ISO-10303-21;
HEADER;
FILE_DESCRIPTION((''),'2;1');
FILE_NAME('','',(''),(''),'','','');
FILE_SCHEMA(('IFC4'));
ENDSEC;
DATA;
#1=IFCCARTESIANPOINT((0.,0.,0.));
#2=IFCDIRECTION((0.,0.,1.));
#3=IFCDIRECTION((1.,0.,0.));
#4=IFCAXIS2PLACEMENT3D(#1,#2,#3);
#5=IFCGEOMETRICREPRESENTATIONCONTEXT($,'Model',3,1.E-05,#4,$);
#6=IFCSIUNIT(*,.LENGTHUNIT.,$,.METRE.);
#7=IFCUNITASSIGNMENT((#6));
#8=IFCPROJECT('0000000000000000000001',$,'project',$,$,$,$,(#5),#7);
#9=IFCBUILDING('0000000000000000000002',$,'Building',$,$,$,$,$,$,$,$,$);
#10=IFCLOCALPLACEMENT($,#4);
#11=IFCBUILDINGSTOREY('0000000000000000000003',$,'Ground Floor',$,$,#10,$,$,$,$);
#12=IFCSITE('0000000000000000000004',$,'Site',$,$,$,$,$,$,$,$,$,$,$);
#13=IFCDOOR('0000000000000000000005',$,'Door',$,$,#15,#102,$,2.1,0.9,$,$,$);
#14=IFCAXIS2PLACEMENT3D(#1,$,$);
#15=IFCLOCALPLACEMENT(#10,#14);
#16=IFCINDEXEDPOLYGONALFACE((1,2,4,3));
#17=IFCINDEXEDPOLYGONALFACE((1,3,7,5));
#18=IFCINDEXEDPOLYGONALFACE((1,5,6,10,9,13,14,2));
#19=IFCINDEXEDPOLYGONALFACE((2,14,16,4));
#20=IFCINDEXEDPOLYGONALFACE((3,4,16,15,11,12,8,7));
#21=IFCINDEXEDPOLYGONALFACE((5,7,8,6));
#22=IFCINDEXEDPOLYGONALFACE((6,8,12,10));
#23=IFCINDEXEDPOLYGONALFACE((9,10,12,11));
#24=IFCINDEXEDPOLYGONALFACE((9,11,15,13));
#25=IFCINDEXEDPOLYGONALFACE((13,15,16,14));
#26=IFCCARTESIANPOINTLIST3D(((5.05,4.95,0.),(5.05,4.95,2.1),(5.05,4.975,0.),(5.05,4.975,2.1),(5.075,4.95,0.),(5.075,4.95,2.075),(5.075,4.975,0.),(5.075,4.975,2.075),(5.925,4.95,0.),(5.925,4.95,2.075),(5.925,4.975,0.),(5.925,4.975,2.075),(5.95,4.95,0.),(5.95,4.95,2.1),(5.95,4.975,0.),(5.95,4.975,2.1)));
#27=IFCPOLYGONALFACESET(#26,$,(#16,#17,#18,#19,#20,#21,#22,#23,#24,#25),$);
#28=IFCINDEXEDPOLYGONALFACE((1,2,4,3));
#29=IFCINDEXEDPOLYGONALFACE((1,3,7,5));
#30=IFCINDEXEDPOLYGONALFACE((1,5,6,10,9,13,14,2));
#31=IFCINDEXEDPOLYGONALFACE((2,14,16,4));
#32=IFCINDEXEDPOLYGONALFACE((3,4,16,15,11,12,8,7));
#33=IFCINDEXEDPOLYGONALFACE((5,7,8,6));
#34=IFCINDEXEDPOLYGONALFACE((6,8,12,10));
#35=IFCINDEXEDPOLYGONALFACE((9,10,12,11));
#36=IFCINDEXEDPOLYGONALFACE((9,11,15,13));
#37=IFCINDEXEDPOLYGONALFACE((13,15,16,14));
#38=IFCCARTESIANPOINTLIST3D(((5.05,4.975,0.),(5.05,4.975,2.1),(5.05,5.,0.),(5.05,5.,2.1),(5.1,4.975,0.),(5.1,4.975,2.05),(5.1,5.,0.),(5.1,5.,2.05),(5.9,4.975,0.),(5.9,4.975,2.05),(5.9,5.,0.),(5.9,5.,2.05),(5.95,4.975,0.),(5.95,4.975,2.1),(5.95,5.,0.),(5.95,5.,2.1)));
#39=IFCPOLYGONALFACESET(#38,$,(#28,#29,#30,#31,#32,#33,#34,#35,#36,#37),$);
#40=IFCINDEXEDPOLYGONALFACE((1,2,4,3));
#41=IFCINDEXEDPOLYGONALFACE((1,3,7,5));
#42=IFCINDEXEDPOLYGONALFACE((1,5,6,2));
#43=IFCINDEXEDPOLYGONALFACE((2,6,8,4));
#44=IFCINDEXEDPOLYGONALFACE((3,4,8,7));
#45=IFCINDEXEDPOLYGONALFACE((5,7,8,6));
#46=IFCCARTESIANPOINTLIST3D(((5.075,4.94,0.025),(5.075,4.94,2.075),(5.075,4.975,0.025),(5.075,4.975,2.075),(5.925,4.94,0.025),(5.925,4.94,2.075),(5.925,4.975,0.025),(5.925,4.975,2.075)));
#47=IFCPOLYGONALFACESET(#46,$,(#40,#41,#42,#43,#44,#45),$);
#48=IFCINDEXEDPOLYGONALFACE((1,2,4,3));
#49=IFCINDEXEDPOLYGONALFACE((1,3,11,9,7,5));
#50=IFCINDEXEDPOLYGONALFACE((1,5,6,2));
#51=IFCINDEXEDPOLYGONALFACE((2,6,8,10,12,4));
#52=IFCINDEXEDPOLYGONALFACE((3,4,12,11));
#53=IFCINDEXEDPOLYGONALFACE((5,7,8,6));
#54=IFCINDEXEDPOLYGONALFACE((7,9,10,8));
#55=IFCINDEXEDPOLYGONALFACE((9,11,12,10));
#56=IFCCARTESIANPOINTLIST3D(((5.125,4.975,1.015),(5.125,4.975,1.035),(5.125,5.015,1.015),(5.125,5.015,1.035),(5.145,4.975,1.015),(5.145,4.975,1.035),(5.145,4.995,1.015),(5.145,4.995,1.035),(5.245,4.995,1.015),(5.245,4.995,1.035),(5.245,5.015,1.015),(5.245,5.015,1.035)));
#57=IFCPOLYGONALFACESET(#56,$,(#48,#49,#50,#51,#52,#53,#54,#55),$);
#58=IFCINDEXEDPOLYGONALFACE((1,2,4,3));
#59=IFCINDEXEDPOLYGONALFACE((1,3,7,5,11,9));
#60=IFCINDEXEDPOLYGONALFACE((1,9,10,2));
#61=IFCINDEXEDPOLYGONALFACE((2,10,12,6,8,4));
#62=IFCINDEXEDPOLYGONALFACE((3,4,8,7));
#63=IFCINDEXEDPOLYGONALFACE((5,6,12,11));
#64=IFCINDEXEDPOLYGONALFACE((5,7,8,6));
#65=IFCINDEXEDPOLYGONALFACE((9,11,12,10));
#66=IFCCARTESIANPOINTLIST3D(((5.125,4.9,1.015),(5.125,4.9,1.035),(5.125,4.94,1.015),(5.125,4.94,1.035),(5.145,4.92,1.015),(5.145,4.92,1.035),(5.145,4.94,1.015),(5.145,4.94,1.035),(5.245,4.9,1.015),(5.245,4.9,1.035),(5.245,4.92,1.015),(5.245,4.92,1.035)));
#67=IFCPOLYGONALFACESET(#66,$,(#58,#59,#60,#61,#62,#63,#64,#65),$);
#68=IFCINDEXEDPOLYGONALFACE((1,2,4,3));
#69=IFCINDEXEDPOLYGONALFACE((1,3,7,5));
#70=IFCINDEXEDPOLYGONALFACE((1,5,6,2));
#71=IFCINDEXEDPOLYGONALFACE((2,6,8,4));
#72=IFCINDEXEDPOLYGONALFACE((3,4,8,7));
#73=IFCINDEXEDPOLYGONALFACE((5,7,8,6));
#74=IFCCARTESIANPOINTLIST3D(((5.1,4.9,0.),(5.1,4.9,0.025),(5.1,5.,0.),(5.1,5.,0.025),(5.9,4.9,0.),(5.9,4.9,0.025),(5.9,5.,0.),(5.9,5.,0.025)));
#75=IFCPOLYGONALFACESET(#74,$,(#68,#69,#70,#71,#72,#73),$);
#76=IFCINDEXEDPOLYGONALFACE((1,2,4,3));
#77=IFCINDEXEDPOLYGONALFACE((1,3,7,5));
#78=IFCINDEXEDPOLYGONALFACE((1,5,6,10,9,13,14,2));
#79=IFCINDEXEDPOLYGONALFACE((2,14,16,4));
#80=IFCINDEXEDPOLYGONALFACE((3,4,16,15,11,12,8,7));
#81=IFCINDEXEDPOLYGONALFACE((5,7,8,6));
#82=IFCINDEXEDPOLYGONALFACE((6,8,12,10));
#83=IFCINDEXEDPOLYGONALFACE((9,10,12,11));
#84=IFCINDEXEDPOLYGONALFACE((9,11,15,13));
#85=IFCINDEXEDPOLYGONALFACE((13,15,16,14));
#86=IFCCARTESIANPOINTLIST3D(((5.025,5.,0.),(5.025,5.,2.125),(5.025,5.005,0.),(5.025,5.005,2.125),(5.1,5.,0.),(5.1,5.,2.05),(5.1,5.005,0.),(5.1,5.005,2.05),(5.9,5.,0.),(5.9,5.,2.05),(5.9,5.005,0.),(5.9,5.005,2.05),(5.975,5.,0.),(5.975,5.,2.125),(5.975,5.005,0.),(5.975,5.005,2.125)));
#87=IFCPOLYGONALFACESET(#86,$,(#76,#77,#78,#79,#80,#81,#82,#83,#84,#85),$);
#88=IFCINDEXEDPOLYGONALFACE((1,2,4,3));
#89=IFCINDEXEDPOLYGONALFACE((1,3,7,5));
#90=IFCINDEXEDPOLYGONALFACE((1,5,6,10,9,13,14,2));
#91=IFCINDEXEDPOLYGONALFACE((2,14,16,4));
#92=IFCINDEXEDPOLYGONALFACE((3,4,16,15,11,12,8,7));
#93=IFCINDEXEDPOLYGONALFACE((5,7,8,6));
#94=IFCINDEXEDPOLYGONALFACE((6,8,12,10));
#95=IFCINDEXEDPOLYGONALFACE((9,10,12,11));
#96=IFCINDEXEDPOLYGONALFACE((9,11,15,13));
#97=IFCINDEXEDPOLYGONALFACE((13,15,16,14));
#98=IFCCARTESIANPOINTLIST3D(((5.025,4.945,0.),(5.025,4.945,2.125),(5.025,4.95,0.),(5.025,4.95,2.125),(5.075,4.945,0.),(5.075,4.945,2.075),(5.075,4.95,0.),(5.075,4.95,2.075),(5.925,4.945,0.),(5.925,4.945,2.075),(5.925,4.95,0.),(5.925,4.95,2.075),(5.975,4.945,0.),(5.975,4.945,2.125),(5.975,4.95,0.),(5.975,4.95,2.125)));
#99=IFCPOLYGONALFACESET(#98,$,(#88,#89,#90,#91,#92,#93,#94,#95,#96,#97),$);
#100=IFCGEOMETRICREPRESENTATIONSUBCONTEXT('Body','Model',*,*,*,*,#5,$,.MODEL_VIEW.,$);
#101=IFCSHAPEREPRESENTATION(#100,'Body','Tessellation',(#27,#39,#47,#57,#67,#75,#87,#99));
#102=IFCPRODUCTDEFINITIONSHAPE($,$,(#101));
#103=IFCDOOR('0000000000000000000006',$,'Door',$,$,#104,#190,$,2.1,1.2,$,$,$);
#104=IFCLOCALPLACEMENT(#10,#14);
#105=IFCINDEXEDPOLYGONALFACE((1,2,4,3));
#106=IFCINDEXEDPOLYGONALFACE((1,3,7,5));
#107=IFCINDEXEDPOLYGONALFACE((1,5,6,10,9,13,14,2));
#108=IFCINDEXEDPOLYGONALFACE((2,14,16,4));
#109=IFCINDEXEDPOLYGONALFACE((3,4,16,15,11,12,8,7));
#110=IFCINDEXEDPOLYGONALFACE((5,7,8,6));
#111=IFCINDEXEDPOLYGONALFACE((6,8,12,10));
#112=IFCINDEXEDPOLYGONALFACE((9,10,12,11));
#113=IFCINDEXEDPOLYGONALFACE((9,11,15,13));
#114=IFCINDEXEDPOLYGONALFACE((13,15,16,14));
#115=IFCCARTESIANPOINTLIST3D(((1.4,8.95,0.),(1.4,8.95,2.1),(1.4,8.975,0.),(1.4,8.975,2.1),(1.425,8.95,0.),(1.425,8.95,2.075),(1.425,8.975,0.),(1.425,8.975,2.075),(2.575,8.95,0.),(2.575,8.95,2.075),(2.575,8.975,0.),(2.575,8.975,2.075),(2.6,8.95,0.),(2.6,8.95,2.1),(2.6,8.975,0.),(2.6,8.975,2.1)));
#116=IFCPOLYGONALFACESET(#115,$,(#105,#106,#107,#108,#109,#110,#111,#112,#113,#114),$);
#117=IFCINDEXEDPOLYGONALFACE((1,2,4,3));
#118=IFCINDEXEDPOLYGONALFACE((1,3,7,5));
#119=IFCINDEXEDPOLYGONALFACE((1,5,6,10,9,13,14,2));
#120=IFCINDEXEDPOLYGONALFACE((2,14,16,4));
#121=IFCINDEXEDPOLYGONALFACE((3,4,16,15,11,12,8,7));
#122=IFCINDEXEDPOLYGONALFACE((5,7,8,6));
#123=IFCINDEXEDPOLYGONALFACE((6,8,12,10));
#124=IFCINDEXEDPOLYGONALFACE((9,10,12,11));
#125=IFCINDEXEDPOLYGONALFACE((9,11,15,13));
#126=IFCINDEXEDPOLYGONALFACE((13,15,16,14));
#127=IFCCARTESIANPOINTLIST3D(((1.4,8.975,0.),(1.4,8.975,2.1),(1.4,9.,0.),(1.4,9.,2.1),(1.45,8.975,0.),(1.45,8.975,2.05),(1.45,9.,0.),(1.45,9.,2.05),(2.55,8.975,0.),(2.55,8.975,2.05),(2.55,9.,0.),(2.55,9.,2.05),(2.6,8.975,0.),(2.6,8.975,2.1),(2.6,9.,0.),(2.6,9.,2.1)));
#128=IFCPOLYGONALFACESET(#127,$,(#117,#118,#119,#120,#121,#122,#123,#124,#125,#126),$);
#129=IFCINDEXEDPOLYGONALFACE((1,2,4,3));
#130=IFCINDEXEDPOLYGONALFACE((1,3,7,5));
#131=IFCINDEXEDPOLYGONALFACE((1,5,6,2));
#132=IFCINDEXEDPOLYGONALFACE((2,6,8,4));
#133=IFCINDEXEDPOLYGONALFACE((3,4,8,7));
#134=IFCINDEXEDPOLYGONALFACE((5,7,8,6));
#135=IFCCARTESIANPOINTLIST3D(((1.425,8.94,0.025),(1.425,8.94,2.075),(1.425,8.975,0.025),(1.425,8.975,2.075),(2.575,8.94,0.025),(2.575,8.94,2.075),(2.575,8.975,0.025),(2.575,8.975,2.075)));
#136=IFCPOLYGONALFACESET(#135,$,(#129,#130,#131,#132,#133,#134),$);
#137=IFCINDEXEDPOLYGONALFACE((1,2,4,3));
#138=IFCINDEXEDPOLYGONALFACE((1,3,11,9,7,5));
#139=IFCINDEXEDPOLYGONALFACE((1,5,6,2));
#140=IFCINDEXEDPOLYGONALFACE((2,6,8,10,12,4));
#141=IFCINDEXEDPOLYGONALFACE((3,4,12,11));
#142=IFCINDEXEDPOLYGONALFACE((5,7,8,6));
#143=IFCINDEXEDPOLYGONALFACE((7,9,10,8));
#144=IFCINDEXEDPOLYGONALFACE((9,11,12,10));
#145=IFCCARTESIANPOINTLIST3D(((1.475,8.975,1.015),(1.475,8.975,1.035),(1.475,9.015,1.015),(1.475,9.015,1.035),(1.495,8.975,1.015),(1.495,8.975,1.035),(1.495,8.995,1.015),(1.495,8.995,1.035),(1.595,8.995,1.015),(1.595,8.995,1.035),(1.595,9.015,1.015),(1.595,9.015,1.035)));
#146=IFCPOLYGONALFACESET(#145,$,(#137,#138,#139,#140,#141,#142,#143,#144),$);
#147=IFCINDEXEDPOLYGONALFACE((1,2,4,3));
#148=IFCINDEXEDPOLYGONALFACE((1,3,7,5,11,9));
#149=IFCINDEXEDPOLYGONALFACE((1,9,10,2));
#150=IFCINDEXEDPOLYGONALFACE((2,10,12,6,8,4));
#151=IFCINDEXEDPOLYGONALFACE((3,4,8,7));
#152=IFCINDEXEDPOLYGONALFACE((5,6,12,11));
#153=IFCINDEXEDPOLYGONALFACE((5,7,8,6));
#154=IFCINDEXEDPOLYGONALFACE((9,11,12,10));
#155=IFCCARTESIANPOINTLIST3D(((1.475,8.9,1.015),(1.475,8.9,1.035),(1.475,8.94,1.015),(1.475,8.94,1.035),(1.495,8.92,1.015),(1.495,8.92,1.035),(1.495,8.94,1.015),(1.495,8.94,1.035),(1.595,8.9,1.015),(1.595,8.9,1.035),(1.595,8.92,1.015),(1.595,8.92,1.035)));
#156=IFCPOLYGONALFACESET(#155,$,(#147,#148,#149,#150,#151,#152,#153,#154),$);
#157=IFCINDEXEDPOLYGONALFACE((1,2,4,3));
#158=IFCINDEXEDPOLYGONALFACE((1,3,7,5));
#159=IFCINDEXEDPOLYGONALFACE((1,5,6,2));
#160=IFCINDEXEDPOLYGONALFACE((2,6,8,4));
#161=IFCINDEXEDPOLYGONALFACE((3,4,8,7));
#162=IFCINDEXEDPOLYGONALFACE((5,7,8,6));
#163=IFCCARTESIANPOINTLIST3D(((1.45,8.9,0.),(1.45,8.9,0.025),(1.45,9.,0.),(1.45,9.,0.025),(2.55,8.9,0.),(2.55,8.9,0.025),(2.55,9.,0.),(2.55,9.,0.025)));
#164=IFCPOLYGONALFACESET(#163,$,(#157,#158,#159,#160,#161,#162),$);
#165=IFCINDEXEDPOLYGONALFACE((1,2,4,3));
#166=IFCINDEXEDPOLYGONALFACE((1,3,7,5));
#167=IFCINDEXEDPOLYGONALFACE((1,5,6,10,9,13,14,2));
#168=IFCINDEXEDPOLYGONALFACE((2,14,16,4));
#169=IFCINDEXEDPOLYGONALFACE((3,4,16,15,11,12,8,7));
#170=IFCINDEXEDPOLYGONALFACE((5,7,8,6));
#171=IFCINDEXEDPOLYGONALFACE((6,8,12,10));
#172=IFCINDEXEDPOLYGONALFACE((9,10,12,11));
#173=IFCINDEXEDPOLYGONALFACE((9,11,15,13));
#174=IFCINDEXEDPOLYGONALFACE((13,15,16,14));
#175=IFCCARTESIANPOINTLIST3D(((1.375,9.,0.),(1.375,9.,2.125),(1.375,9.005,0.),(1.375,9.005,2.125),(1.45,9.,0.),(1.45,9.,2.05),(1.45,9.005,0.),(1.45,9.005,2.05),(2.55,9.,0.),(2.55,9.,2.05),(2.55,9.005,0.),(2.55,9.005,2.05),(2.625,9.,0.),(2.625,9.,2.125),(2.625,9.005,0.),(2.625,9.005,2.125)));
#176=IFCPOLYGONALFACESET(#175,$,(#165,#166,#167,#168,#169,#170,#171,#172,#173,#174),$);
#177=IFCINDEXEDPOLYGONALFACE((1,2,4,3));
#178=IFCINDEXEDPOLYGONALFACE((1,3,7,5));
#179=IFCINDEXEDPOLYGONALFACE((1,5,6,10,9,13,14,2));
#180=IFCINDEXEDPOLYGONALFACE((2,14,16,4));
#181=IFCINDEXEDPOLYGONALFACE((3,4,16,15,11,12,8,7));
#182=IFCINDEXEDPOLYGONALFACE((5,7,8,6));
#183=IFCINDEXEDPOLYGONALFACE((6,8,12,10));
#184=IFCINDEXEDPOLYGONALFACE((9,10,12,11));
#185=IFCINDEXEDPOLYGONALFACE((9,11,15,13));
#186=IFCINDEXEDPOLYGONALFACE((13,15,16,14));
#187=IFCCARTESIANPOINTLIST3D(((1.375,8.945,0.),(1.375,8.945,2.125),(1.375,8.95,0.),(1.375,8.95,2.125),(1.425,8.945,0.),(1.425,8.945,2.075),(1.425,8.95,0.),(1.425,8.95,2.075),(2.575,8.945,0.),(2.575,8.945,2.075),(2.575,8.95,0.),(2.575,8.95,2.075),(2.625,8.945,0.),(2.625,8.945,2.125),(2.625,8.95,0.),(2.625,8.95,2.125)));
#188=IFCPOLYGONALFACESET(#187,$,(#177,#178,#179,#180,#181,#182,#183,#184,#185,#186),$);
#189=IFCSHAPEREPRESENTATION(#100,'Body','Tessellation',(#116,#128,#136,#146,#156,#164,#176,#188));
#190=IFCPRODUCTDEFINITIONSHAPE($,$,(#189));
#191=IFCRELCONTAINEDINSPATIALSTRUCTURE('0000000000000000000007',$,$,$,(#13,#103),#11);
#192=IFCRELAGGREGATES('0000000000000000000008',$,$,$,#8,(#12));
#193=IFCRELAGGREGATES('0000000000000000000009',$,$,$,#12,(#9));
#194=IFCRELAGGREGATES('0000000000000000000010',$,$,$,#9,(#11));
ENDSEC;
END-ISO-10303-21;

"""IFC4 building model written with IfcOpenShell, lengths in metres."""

from ifc_helpers import new_model, si_unit, frame, origin_with_axes, place, context, subcontext, project, spatial, line, indexed_curve, outline, extrude, element, save


model = new_model("IFC4")

# Units and contexts
model_context = context("Model", 3, precision=1e-05, world=origin_with_axes())
body_context = subcontext(model_context, "Body", "Model", "MODEL_VIEW")
ifc_project = project(units=[si_unit("LENGTHUNIT", "METRE")], contexts=[model_context])

# Site, building, storey
site = spatial("IfcSite", under=ifc_project, Name="Site")
building = spatial("IfcBuilding", under=site, Name="Building")
storey_placement = place(None, origin_with_axes())
storey = spatial("IfcBuildingStorey", under=building, at=storey_placement, Name="Ground Floor")

# Doors
door_1_placement = place(storey_placement, frame((5.95, 5.0, 0.0), z_axis=(0.0, 0.0, 1.0), x_axis=(-1.0, 0.0, 0.0)))
element("IfcDoor", 1, at=door_1_placement, inside=storey, Name="Door", OverallHeight=2.1, OverallWidth=0.9, context=body_context, shape_type="SweptSolid", body=[
    extrude(outline(indexed_curve([(0.0, 0.0), (0.0, 2.1), (0.9, 2.1), (0.9, 0.0), (0.875, 0.0), (0.875, 2.075), (0.025, 2.075), (0.025, 0.0)], segments=[line(1, 2, 3, 4, 5, 6, 7, 8, 1)])), frame((0.0, 0.025, 0.0), z_axis=(0.0, -1.0, 0.0), x_axis=(1.0, 0.0, 0.0)), (0.0, 0.0, -1.0), 0.025),
    extrude(outline(indexed_curve([(0.0, 0.0), (0.0, 2.1), (0.9, 2.1), (0.9, 0.0), (0.85, 0.0), (0.85, 2.05), (0.05, 2.05), (0.05, 0.0)], segments=[line(1, 2, 3, 4, 5, 6, 7, 8, 1)])), frame((0.0, 0.0, 0.0), z_axis=(0.0, -1.0, 0.0), x_axis=(1.0, 0.0, 0.0)), (0.0, 0.0, -1.0), 0.025),
    extrude(outline(indexed_curve([(0.0, 0.0), (0.85, 0.0), (0.85, 0.035), (0.0, 0.035)], segments=[line(1, 2, 3, 4, 1)])), frame((0.025, 0.025, 0.025), z_axis=(0.0, 0.0, 1.0), x_axis=(1.0, 0.0, 0.0)), (0.0, 0.0, 1.0), 2.05),
    extrude(outline(indexed_curve([(0.0, 0.0), (0.0, -0.04), (-0.12, -0.04), (-0.12, -0.02), (-0.02, -0.02), (-0.02, 0.0)], segments=[line(1, 2, 3, 4, 5, 6, 1)])), frame((0.825, 0.025, 1.015), z_axis=(0.0, 0.0, 1.0), x_axis=(1.0, 0.0, 0.0)), (0.0, 0.0, 1.0), 0.02),
    extrude(outline(indexed_curve([(0.0, 0.0), (0.0, 0.04), (-0.12, 0.04), (-0.12, 0.02), (-0.02, 0.02), (-0.02, 0.0)], segments=[line(1, 2, 3, 4, 5, 6, 1)])), frame((0.825, 0.06, 1.015), z_axis=(0.0, 0.0, 1.0), x_axis=(1.0, 0.0, 0.0)), (0.0, 0.0, 1.0), 0.02),
    extrude(outline(indexed_curve([(0.0, 0.0), (0.8, 0.0), (0.8, 0.1), (0.0, 0.1)], segments=[line(1, 2, 3, 4, 1)])), frame((0.05, 0.0, 0.0), z_axis=(0.0, 0.0, 1.0), x_axis=(1.0, 0.0, 0.0)), (0.0, 0.0, 1.0), 0.025),
    extrude(outline(indexed_curve([(0.0, 0.0), (0.0, 2.125), (0.95, 2.125), (0.95, 0.0), (0.875, 0.0), (0.875, 2.05), (0.075, 2.05), (0.075, 0.0)], segments=[line(1, 2, 3, 4, 5, 6, 7, 8, 1)])), frame((-0.025, -0.005, 0.0), z_axis=(0.0, -1.0, 0.0), x_axis=(1.0, 0.0, 0.0)), (0.0, 0.0, -1.0), 0.005),
    extrude(outline(indexed_curve([(0.0, 0.0), (0.0, 2.125), (0.95, 2.125), (0.95, 0.0), (0.9, 0.0), (0.9, 2.075), (0.05, 2.075), (0.05, 0.0)], segments=[line(1, 2, 3, 4, 5, 6, 7, 8, 1)])), frame((-0.025, 0.05, 0.0), z_axis=(0.0, -1.0, 0.0), x_axis=(1.0, 0.0, 0.0)), (0.0, 0.0, -1.0), 0.005),
])
door_2_placement = place(storey_placement, frame((2.6, 9.0, 0.0), z_axis=(0.0, 0.0, 1.0), x_axis=(-1.0, 0.0, 0.0)))
element("IfcDoor", 2, at=door_2_placement, inside=storey, Name="Door", OverallHeight=2.1, OverallWidth=1.2, context=body_context, shape_type="SweptSolid", body=[
    extrude(outline(indexed_curve([(0.0, 0.0), (0.0, 2.1), (1.2, 2.1), (1.2, 0.0), (1.175, 0.0), (1.175, 2.075), (0.025, 2.075), (0.025, 0.0)], segments=[line(1, 2, 3, 4, 5, 6, 7, 8, 1)])), frame((0.0, 0.025, 0.0), z_axis=(0.0, -1.0, 0.0), x_axis=(1.0, 0.0, 0.0)), (0.0, 0.0, -1.0), 0.025),
    extrude(outline(indexed_curve([(0.0, 0.0), (0.0, 2.1), (1.2, 2.1), (1.2, 0.0), (1.15, 0.0), (1.15, 2.05), (0.05, 2.05), (0.05, 0.0)], segments=[line(1, 2, 3, 4, 5, 6, 7, 8, 1)])), frame((0.0, 0.0, 0.0), z_axis=(0.0, -1.0, 0.0), x_axis=(1.0, 0.0, 0.0)), (0.0, 0.0, -1.0), 0.025),
    extrude(outline(indexed_curve([(0.0, 0.0), (1.15, 0.0), (1.15, 0.035), (0.0, 0.035)], segments=[line(1, 2, 3, 4, 1)])), frame((0.025, 0.025, 0.025), z_axis=(0.0, 0.0, 1.0), x_axis=(1.0, 0.0, 0.0)), (0.0, 0.0, 1.0), 2.05),
    extrude(outline(indexed_curve([(0.0, 0.0), (0.0, -0.04), (-0.12, -0.04), (-0.12, -0.02), (-0.02, -0.02), (-0.02, 0.0)], segments=[line(1, 2, 3, 4, 5, 6, 1)])), frame((1.125, 0.025, 1.015), z_axis=(0.0, 0.0, 1.0), x_axis=(1.0, 0.0, 0.0)), (0.0, 0.0, 1.0), 0.02),
    extrude(outline(indexed_curve([(0.0, 0.0), (0.0, 0.04), (-0.12, 0.04), (-0.12, 0.02), (-0.02, 0.02), (-0.02, 0.0)], segments=[line(1, 2, 3, 4, 5, 6, 1)])), frame((1.125, 0.06, 1.015), z_axis=(0.0, 0.0, 1.0), x_axis=(1.0, 0.0, 0.0)), (0.0, 0.0, 1.0), 0.02),
    extrude(outline(indexed_curve([(0.0, 0.0), (1.1, 0.0), (1.1, 0.1), (0.0, 0.1)], segments=[line(1, 2, 3, 4, 1)])), frame((0.05, 0.0, 0.0), z_axis=(0.0, 0.0, 1.0), x_axis=(1.0, 0.0, 0.0)), (0.0, 0.0, 1.0), 0.025),
    extrude(outline(indexed_curve([(0.0, 0.0), (0.0, 2.125), (1.25, 2.125), (1.25, 0.0), (1.175, 0.0), (1.175, 2.05), (0.075, 2.05), (0.075, 0.0)], segments=[line(1, 2, 3, 4, 5, 6, 7, 8, 1)])), frame((-0.025, -0.005, 0.0), z_axis=(0.0, -1.0, 0.0), x_axis=(1.0, 0.0, 0.0)), (0.0, 0.0, -1.0), 0.005),
    extrude(outline(indexed_curve([(0.0, 0.0), (0.0, 2.125), (1.25, 2.125), (1.25, 0.0), (1.2, 0.0), (1.2, 2.075), (0.05, 2.075), (0.05, 0.0)], segments=[line(1, 2, 3, 4, 5, 6, 7, 8, 1)])), frame((-0.025, 0.05, 0.0), z_axis=(0.0, -1.0, 0.0), x_axis=(1.0, 0.0, 0.0)), (0.0, 0.0, -1.0), 0.005),
])

save(model, "model.ifc")
